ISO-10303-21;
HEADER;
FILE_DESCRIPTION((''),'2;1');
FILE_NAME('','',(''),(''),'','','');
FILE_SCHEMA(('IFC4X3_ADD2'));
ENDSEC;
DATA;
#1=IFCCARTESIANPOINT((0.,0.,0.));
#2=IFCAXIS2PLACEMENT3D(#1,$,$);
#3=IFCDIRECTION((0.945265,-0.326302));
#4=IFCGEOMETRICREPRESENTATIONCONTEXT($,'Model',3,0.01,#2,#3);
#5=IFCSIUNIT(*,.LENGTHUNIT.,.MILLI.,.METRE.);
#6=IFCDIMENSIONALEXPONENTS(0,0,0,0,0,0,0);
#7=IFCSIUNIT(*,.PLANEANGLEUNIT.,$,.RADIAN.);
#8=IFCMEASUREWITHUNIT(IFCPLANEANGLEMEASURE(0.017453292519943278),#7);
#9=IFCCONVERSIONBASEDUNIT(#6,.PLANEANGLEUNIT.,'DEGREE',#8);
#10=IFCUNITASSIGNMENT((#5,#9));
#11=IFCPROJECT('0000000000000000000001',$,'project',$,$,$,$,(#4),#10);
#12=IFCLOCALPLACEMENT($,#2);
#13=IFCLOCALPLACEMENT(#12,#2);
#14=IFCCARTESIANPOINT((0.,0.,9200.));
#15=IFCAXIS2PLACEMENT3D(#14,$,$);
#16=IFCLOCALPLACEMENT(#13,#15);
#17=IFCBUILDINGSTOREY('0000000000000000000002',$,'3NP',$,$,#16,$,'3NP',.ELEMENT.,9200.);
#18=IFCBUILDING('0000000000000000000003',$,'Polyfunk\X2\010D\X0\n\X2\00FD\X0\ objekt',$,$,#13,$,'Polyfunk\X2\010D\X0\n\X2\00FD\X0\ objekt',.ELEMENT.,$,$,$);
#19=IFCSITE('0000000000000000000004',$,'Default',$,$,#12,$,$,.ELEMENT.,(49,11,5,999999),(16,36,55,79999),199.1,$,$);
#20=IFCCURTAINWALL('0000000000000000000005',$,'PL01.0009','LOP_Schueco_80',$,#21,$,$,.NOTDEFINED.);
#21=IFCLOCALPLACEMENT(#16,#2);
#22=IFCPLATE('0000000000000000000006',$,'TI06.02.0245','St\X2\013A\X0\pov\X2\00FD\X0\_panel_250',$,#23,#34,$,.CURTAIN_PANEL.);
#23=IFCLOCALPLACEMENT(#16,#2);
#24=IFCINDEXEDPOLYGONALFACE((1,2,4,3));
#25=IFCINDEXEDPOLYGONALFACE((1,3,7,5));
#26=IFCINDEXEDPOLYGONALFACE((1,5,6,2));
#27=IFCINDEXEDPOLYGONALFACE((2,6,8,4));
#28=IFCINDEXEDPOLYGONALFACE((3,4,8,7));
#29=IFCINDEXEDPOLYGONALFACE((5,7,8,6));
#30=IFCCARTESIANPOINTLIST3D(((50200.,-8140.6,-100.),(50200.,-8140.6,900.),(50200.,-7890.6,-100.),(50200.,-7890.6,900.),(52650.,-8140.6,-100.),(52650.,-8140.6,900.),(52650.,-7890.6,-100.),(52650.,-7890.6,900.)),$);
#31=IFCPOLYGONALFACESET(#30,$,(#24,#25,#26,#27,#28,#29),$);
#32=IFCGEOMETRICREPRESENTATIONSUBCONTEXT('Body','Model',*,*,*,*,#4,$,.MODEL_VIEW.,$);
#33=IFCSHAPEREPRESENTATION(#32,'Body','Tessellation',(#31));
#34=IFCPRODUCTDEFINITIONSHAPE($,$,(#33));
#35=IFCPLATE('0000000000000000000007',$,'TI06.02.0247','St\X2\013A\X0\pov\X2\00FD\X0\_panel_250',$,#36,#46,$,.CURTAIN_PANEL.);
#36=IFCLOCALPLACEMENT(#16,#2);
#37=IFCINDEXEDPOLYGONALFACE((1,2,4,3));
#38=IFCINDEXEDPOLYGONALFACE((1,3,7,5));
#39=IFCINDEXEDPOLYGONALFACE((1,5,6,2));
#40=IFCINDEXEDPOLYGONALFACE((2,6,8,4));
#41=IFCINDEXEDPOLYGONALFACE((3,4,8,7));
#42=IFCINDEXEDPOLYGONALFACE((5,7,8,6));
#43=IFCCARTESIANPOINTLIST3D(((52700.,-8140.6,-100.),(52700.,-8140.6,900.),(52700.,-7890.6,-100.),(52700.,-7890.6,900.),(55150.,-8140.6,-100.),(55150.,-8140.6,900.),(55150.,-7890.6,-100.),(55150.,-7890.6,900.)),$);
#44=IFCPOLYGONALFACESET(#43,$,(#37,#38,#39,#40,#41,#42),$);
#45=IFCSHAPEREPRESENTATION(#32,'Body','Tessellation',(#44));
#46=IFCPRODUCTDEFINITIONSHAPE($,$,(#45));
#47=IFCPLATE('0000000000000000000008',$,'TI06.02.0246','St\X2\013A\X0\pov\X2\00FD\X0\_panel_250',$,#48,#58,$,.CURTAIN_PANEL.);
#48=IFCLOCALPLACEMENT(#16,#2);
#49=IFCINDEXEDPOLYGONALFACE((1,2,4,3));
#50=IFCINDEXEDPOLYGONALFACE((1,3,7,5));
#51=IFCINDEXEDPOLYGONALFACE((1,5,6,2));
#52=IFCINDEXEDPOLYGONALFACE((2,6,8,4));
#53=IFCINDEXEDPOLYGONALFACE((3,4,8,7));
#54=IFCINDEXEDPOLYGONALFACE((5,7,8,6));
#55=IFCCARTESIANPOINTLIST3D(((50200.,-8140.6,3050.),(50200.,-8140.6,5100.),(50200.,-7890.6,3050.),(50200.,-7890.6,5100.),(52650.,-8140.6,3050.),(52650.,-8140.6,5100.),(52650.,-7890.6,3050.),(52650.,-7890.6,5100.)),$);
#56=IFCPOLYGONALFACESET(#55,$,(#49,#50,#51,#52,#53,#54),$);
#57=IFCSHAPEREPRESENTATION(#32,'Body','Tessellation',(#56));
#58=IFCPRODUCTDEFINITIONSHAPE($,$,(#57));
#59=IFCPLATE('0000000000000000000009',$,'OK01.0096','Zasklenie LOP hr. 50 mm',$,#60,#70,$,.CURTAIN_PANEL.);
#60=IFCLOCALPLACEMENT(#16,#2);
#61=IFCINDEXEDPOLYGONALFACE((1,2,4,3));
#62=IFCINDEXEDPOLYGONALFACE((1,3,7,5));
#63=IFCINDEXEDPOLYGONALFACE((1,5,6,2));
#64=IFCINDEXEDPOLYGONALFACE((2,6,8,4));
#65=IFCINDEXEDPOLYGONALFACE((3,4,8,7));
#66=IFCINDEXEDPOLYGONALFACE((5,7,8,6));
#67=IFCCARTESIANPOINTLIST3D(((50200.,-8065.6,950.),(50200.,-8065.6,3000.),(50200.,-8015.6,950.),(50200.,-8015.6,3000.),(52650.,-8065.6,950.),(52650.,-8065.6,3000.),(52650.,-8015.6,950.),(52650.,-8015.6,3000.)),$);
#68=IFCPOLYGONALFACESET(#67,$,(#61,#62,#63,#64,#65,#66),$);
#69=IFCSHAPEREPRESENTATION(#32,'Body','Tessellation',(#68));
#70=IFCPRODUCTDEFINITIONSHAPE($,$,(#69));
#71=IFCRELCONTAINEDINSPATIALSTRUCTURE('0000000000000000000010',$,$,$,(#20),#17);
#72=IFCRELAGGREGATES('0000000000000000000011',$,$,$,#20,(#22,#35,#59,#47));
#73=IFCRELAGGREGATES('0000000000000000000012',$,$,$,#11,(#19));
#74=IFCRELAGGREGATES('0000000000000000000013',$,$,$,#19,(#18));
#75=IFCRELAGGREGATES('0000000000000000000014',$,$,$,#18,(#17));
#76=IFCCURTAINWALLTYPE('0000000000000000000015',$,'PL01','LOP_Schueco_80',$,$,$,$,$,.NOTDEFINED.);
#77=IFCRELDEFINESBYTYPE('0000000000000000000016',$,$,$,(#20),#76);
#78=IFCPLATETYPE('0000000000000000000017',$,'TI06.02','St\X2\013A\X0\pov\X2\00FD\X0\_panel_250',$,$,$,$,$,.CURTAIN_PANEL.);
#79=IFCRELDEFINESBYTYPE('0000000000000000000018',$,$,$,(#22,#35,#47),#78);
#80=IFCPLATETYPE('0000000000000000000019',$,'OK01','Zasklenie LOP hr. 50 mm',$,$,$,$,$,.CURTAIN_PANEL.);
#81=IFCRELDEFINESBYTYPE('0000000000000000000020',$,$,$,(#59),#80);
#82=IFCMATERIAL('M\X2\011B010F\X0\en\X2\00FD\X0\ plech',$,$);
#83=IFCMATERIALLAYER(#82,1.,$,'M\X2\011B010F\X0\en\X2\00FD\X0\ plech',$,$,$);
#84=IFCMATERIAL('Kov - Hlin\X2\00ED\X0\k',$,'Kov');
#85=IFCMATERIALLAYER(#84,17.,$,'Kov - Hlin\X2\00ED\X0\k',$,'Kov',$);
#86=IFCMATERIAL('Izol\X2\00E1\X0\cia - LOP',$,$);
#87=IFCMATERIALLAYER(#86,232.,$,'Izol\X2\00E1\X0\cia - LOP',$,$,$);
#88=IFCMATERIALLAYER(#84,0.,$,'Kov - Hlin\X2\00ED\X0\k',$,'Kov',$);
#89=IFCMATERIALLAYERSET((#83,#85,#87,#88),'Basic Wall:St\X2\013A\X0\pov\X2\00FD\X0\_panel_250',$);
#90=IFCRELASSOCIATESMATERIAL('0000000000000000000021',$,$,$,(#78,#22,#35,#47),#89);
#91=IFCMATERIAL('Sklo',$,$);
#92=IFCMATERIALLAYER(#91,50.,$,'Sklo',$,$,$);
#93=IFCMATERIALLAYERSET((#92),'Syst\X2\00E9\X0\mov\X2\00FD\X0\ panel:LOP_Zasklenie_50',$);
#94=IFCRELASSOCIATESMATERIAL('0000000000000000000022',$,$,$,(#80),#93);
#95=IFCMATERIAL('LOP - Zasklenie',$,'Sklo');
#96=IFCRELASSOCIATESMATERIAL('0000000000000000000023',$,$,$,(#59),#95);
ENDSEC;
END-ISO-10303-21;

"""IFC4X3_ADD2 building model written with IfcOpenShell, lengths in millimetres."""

from ifc_helpers import new_model, entity, si_unit, converted_unit, direction, frame, frame_2d, origin, origin_2d_with_axis, place, context, subcontext, project, spatial, rectangle, extrude, source, transform, mapped, material, layer, layer_set, layer_usage, type_object, type_shapes, element, aggregate, save


model = new_model("IFC4X3_ADD2")

# Units and contexts
model_context = context("Model", 3, precision=0.01, world=origin(), true_north=direction((0.945265, -0.326302)))
body_context = subcontext(model_context, "Body", "Model", "MODEL_VIEW")
ifc_project = project(units=[si_unit("LENGTHUNIT", "METRE", prefix="MILLI"), converted_unit("PLANEANGLEUNIT", "DEGREE", entity("IfcPlaneAngleMeasure", 0.017453292519943278), si_unit("PLANEANGLEUNIT", "RADIAN"), dimensions=[0, 0, 0, 0, 0, 0, 0])], contexts=[model_context])

# Site, building, storey
site_placement = place(None, origin())
site = spatial("IfcSite", under=ifc_project, at=site_placement, Name="Default", CompositionType="ELEMENT", RefLatitude=(49, 11, 5, 999999), RefLongitude=(16, 36, 55, 79999), RefElevation=199.1)
building_placement = place(site_placement, origin())
building = spatial("IfcBuilding", under=site, at=building_placement, Name="Polyfunkčný objekt", LongName="Polyfunkčný objekt", CompositionType="ELEMENT")
storey_placement = place(building_placement, frame((0.0, 0.0, 9200.0)))
storey = spatial("IfcBuildingStorey", under=building, at=storey_placement, Name="3NP", LongName="3NP", CompositionType="ELEMENT", Elevation=9200.0)

# Curtain wall, plates
curtain_wall_type = type_object("IfcCurtainWallType", Name="PL01", Description="LOP_Schueco_80", PredefinedType="NOTDEFINED")
curtain_wall_placement = place(storey_placement, frame((0.0, 0.0, -9200.0)))
curtain_wall = element("IfcCurtainWall", 1, at=curtain_wall_placement, inside=storey, type_object=curtain_wall_type, Name="PL01.0009", Description="LOP_Schueco_80", PredefinedType="NOTDEFINED")
ifc_material_1 = material(Name="Měďený plech")
ifc_layer_1 = layer(ifc_material_1, 1.0, Name="Měďený plech")
ifc_material_2 = material(Name="Kov - Hliník", Category="Kov")
ifc_layer_2 = layer(ifc_material_2, 17.0, Name="Kov - Hliník", Category="Kov")
ifc_material_3 = material(Name="Izolácia - LOP")
ifc_layer_3 = layer(ifc_material_3, 232.0, Name="Izolácia - LOP")
ifc_layer_4 = layer(ifc_material_2, 0.0, Name="Kov - Hliník", Category="Kov")
ifc_layer_set_1 = layer_set([ifc_layer_1, ifc_layer_2, ifc_layer_3, ifc_layer_4], Name="Basic Wall:Stĺpový_panel_250")
ifc_layer_usage_1 = layer_usage(ifc_layer_set_1, "AXIS2", "POSITIVE", -125.0)
plate_type_1 = type_object("IfcPlateType", Name="TI06.02", Description="Stĺpový_panel_250", PredefinedType="CURTAIN_PANEL", material=ifc_layer_set_1)
plate_1_placement = place(storey_placement, frame((50200.0, -8015.6, -100.0)))
plate_1 = element("IfcPlate", 2, at=plate_1_placement, type_object=plate_type_1, material=ifc_layer_usage_1, Name="TI06.02.0245", Description="Stĺpový_panel_250", PredefinedType="CURTAIN_PANEL", context=body_context, shape_type="SweptSolid", body=[
    extrude(rectangle(XDim=250.0, YDim=2450.0, at=origin_2d_with_axis()), frame((1225.0, 0.0, 0.0), z_axis=(0.0, 0.0, 1.0), x_axis=(0.0, 1.0, 0.0)), (0.0, 0.0, 1.0), 1000.0),
])
ifc_layer_usage_2 = layer_usage(ifc_layer_set_1, "AXIS2", "POSITIVE", -125.0)
plate_2_placement = place(storey_placement, frame((52700.0, -8015.6, -100.0)))
plate_2 = element("IfcPlate", 3, at=plate_2_placement, type_object=plate_type_1, material=ifc_layer_usage_2, Name="TI06.02.0247", Description="Stĺpový_panel_250", PredefinedType="CURTAIN_PANEL", context=body_context, shape_type="SweptSolid", body=[
    extrude(rectangle(XDim=250.0, YDim=2450.0, at=frame_2d((0.0, 0.0), x_axis=(1.0, 0.0))), frame((1225.0, 0.0, 0.0), z_axis=(0.0, 0.0, 1.0), x_axis=(0.0, 1.0, 0.0)), (0.0, 0.0, 1.0), 1000.0),
])
ifc_layer_usage_3 = layer_usage(ifc_layer_set_1, "AXIS2", "POSITIVE", -125.0)
plate_3_placement = place(storey_placement, frame((50200.0, -8015.6, 3050.0)))
plate_3 = element("IfcPlate", 4, at=plate_3_placement, type_object=plate_type_1, material=ifc_layer_usage_3, Name="TI06.02.0246", Description="Stĺpový_panel_250", PredefinedType="CURTAIN_PANEL", context=body_context, shape_type="SweptSolid", body=[
    extrude(rectangle(XDim=250.0, YDim=2450.0, at=origin_2d_with_axis()), frame((1225.0, 0.0, 0.0), z_axis=(0.0, 0.0, 1.0), x_axis=(0.0, 1.0, 0.0)), (0.0, 0.0, 1.0), 2050.0),
])
ifc_material_4 = material(Name="LOP - Zasklenie", Category="Sklo")
ifc_material_5 = material(Name="Sklo")
ifc_layer_5 = layer(ifc_material_5, 50.0, Name="Sklo")
ifc_layer_set_2 = layer_set([ifc_layer_5], Name="Systémový panel:LOP_Zasklenie_50")
plate_type_2 = type_object("IfcPlateType", Name="OK01", Description="Zasklenie LOP hr. 50 mm", PredefinedType="CURTAIN_PANEL", material=ifc_layer_set_2)
shared_shape_1 = source(origin(), body_context, "Body", "SweptSolid", [
    extrude(rectangle(XDim=50.0, YDim=2450.0, at=origin_2d_with_axis()), frame((0.0, -25.0, 0.0), z_axis=(0.0, 0.0, 1.0), x_axis=(0.0, 1.0, 0.0)), (0.0, 0.0, 1.0), 2050.0),
])
type_shapes(plate_type_2, [shared_shape_1])
plate_4_placement = place(curtain_wall_placement, frame((51425.0, -8015.6, 10150.0)))
plate_4 = element("IfcPlate", 5, at=plate_4_placement, type_object=plate_type_2, material=ifc_material_4, Name="OK01.0096", Description="Zasklenie LOP hr. 50 mm", PredefinedType="CURTAIN_PANEL", context=body_context, shape_type="MappedRepresentation", body=[
    mapped(shared_shape_1, transform((0.0, 0.0, 0.0), scale=1.0)),
])
aggregate(curtain_wall, [plate_1, plate_2, plate_4, plate_3])

save(model, "model.ifc")
